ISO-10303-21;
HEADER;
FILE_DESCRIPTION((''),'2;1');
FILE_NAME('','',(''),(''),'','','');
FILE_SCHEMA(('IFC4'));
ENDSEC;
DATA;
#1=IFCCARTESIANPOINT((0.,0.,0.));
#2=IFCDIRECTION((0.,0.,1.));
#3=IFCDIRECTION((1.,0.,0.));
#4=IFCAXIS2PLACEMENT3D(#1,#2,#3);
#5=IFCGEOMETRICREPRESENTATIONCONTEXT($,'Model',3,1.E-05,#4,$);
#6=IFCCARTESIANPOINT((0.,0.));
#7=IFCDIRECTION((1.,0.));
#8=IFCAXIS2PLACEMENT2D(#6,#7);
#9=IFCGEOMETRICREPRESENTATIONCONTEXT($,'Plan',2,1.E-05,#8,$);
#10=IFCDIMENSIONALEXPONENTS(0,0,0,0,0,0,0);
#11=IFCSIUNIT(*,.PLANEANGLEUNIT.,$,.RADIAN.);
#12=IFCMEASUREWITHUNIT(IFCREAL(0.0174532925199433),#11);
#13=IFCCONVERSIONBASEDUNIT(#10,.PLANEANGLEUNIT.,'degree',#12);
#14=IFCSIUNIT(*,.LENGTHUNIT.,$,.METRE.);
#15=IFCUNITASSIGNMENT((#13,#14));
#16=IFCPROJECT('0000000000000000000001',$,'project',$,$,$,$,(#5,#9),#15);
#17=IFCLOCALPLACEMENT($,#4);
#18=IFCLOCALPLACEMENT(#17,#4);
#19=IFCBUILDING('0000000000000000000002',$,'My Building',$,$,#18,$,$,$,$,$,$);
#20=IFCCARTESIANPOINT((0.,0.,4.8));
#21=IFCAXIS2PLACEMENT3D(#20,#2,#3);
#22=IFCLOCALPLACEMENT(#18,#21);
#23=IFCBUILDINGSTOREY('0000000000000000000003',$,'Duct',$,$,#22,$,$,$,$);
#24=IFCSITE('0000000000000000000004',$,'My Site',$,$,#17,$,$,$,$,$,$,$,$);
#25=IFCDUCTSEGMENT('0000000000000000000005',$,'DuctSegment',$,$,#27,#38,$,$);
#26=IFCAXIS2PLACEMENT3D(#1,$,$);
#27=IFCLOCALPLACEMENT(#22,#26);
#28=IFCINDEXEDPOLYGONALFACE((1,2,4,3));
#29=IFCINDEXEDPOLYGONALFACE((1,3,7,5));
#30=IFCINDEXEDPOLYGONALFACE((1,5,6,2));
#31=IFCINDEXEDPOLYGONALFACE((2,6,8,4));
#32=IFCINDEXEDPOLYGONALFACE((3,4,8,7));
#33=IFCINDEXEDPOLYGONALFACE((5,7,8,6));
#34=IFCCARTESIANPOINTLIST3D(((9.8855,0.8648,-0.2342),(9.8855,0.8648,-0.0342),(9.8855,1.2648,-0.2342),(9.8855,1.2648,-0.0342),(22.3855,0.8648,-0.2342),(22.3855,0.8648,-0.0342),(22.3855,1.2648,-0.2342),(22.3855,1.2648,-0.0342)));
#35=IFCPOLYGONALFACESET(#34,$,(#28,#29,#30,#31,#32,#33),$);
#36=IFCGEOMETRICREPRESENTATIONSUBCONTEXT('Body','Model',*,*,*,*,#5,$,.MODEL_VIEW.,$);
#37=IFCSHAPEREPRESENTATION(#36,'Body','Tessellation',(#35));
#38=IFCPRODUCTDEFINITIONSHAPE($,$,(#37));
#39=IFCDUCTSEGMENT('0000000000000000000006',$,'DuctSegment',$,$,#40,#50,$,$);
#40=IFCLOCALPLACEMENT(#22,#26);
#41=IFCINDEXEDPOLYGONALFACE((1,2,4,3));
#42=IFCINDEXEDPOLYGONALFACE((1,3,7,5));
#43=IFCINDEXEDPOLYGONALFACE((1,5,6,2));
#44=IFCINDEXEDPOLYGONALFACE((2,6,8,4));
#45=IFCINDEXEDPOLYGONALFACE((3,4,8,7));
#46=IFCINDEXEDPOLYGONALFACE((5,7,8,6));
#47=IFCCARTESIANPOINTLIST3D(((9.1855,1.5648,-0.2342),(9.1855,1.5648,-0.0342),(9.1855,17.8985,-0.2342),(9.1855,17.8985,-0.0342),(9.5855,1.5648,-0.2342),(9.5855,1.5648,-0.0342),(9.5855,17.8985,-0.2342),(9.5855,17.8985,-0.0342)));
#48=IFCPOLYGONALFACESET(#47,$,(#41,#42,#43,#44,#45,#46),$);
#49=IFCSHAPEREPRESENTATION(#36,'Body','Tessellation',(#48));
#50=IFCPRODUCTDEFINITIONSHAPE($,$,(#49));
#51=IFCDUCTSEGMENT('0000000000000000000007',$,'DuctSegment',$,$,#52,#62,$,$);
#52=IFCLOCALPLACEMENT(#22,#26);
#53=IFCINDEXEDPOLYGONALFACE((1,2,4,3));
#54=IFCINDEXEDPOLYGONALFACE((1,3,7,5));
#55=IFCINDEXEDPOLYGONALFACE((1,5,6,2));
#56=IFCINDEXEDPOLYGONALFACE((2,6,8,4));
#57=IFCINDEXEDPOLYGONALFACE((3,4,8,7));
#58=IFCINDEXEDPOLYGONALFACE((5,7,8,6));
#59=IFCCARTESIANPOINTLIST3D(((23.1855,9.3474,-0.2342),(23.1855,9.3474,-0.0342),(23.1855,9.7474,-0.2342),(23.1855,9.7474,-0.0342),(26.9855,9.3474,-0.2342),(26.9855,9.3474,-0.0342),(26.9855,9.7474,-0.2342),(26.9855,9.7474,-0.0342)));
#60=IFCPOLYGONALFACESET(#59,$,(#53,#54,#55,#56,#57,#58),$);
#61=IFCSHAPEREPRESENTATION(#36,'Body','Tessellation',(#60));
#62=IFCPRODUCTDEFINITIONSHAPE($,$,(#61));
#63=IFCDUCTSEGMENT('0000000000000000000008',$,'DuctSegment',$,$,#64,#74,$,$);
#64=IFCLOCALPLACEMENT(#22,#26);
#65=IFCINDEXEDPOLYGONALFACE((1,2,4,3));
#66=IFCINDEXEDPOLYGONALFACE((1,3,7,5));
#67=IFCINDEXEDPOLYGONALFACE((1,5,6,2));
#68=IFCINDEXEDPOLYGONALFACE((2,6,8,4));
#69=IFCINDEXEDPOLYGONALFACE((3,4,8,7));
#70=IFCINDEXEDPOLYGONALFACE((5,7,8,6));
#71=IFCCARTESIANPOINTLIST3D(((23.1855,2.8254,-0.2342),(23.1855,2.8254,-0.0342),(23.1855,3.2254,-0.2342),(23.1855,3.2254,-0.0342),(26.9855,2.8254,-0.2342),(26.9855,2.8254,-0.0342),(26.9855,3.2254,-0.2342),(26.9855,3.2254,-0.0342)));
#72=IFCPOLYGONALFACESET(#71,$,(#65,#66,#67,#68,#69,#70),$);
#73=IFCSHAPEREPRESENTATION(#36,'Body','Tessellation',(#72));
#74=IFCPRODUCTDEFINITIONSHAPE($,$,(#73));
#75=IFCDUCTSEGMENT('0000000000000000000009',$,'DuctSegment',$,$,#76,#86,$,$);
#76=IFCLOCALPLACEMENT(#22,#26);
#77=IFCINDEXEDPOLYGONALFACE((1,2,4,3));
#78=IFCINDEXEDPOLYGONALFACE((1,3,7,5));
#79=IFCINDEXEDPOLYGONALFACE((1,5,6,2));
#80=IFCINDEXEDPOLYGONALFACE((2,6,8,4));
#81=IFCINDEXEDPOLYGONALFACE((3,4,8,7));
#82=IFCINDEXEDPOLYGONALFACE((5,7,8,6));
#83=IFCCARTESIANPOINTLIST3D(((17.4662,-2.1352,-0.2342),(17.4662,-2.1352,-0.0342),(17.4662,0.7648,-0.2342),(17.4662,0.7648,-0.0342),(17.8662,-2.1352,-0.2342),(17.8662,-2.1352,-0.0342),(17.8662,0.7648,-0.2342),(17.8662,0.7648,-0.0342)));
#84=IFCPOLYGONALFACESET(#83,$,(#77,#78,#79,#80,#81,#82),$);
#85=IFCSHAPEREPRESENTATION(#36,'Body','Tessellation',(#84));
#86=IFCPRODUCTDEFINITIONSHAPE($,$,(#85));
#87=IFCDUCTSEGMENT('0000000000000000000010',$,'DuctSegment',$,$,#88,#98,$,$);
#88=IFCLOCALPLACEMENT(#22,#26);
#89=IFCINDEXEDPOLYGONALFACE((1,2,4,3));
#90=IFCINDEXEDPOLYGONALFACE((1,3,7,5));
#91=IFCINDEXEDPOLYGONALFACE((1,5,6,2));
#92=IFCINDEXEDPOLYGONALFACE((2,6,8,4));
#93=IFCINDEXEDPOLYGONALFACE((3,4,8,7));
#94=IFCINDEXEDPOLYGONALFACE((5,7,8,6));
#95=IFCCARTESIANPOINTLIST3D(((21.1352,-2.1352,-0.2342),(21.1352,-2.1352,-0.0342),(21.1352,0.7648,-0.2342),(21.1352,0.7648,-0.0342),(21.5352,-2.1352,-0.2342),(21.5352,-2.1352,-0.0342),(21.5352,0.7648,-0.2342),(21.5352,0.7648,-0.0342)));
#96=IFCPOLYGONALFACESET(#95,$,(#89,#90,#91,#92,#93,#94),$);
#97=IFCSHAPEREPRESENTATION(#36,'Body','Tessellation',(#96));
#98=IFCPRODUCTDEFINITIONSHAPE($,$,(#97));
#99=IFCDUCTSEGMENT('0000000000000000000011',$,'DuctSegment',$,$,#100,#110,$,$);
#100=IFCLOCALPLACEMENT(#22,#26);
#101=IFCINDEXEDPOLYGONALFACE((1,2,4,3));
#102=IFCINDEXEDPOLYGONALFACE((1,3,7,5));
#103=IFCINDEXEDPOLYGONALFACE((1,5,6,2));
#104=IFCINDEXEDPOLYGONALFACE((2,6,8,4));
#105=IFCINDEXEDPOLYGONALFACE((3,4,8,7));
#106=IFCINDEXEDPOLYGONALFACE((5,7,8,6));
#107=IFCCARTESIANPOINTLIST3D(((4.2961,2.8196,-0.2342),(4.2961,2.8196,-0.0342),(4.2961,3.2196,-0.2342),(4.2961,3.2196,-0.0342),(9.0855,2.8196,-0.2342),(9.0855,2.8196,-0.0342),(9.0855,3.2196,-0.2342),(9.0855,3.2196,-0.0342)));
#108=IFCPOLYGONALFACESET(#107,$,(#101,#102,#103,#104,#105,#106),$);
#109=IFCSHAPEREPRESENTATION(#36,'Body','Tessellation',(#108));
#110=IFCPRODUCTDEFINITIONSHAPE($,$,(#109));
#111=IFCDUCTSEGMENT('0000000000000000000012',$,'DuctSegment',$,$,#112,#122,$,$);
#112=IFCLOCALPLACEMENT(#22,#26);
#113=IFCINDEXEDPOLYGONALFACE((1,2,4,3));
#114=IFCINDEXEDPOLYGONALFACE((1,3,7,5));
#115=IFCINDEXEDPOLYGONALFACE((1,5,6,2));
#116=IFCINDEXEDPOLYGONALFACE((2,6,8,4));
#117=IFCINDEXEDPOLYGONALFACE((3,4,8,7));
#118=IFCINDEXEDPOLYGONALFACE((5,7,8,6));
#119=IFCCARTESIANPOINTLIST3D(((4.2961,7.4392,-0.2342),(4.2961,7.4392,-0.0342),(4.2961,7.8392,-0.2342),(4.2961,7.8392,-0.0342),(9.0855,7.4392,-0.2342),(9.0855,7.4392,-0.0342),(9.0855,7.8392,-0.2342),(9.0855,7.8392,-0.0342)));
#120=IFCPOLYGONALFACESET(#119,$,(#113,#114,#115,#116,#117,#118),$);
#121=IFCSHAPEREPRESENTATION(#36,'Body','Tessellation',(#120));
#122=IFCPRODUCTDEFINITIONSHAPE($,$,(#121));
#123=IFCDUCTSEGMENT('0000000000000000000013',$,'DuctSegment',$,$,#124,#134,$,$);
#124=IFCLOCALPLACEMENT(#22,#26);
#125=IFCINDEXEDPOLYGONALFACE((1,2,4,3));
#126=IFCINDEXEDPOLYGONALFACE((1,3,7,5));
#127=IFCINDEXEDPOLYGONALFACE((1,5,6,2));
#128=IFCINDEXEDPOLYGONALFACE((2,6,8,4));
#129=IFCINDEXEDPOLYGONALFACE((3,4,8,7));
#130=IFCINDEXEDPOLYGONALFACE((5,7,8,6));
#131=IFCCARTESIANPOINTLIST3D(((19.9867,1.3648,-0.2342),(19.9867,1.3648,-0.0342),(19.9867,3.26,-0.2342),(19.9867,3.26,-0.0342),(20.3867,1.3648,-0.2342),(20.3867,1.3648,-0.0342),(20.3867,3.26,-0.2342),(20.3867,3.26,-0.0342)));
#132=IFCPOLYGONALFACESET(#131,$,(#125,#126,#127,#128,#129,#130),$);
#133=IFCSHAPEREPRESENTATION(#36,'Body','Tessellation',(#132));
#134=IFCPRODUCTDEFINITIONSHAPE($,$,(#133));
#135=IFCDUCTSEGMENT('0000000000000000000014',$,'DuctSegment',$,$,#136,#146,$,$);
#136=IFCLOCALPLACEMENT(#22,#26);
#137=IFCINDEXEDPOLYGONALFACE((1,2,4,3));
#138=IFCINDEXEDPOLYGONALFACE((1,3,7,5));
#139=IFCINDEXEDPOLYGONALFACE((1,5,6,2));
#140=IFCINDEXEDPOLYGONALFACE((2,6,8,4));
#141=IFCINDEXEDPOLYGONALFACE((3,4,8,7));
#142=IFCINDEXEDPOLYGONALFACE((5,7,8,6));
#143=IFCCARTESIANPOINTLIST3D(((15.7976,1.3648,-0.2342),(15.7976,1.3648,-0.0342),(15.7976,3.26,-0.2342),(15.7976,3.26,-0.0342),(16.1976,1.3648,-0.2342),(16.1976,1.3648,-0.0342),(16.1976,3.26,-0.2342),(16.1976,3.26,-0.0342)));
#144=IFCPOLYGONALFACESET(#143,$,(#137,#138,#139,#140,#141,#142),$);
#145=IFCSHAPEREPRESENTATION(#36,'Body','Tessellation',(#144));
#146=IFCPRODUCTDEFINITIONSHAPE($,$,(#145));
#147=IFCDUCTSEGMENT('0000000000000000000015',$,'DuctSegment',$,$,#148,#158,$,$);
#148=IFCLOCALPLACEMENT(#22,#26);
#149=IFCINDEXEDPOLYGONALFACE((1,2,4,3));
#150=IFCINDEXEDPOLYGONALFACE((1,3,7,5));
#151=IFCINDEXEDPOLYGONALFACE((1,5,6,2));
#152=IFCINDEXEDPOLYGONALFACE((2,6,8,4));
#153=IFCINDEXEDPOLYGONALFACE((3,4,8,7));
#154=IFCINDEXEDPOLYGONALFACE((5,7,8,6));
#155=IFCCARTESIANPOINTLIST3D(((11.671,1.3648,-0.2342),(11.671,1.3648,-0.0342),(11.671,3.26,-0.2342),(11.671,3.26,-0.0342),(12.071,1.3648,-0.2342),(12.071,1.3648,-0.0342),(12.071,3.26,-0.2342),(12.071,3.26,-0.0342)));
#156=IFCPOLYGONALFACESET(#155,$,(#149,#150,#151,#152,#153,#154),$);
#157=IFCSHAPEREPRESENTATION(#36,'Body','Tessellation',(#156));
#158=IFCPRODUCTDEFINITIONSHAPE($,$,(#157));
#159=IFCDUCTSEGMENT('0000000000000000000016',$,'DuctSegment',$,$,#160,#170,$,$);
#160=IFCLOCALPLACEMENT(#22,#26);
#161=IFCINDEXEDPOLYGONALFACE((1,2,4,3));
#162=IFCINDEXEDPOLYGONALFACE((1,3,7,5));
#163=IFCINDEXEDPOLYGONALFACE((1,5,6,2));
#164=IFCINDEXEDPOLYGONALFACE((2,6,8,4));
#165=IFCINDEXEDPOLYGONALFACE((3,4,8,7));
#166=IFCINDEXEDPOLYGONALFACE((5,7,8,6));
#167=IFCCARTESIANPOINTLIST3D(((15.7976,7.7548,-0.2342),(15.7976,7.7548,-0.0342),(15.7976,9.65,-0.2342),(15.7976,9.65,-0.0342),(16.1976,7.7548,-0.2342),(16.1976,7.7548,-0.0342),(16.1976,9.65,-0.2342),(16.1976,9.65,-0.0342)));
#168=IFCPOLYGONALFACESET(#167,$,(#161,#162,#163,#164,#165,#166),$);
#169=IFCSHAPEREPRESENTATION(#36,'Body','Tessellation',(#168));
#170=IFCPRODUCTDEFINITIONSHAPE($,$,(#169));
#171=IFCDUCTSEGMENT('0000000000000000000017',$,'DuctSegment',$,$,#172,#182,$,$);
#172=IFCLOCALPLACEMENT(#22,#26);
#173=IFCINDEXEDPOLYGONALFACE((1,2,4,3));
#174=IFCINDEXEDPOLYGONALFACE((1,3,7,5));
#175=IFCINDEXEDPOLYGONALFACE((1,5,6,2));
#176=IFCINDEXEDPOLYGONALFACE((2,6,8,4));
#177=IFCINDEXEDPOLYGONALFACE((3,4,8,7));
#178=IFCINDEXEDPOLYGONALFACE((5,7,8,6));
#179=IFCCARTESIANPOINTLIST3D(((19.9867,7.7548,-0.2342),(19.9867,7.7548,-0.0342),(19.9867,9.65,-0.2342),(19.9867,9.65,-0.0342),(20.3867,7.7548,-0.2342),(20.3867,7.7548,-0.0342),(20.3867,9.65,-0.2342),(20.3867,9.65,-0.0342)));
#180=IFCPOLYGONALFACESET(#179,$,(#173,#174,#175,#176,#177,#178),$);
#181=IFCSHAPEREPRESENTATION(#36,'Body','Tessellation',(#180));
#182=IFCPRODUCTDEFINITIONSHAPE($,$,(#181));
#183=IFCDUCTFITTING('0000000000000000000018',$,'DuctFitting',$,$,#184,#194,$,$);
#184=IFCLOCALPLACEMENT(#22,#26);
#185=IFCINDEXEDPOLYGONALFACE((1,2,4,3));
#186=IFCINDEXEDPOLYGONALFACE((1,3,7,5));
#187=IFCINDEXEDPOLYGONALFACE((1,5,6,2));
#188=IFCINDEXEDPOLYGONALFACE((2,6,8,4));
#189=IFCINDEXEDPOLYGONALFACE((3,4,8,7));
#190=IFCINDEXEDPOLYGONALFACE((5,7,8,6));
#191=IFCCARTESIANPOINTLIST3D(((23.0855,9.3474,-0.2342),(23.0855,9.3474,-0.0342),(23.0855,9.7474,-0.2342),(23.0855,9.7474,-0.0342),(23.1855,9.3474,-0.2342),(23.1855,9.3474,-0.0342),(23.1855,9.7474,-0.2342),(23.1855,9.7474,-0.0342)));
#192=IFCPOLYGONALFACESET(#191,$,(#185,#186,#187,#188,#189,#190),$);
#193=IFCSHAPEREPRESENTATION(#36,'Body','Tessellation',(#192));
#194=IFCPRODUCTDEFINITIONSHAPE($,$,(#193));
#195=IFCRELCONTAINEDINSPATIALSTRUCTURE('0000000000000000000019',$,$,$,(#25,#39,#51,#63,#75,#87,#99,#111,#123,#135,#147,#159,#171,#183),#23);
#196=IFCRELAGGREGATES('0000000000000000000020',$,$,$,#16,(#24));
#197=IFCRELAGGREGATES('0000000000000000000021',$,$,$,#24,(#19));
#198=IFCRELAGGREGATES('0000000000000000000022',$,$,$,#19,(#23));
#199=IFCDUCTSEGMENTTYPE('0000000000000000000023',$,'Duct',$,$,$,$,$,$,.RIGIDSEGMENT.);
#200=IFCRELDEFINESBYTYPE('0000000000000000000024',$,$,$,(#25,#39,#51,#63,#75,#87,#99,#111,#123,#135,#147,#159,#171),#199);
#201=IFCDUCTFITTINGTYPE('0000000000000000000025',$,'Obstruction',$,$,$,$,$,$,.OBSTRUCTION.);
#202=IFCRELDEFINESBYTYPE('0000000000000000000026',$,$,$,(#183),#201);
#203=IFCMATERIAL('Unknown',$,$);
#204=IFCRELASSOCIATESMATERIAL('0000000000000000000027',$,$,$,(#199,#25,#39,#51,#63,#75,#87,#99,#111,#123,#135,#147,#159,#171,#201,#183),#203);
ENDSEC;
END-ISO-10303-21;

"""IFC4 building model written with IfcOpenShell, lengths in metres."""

from ifc_helpers import new_model, entity, si_unit, converted_unit, frame, origin_with_axes, origin_2d_with_axis, place, context, subcontext, project, spatial, rectangle, extrude, material, material_profile, profile_set, profile_usage, type_object, element, save


model = new_model("IFC4")

# Units and contexts
model_context = context("Model", 3, precision=1e-05, world=origin_with_axes())
plan_context = context("Plan", 2, precision=1e-05, world=origin_2d_with_axis())
body_context = subcontext(model_context, "Body", "Model", "MODEL_VIEW")
ifc_project = project(units=[converted_unit("PLANEANGLEUNIT", "degree", entity("IfcReal", 0.0174532925199433), si_unit("PLANEANGLEUNIT", "RADIAN"), dimensions=[0, 0, 0, 0, 0, 0, 0]), si_unit("LENGTHUNIT", "METRE")], contexts=[model_context, plan_context])

# Site, building, storey
site_placement = place(None, origin_with_axes())
site = spatial("IfcSite", under=ifc_project, at=site_placement, Name="My Site")
building_placement = place(site_placement, origin_with_axes())
building = spatial("IfcBuilding", under=site, at=building_placement, Name="My Building")
storey_placement = place(building_placement, frame((0.0, 0.0, 4.8), z_axis=(0.0, 0.0, 1.0), x_axis=(1.0, 0.0, 0.0)))
storey = spatial("IfcBuildingStorey", under=building, at=storey_placement, Name="Duct")

# Duct segments
ifc_material = material(Name="Unknown")
ifc_material_profile_1 = material_profile(ifc_material, rectangle(XDim=0.4, YDim=0.2))
ifc_profile_set_1 = profile_set([ifc_material_profile_1])
ifc_profile_usage_1 = profile_usage(ifc_profile_set_1, cardinal=5)
duct_segment_type = type_object("IfcDuctSegmentType", Name="Duct", PredefinedType="RIGIDSEGMENT", material=ifc_profile_set_1)
duct_segment_1_placement = place(storey_placement, frame((22.3855, 1.0648, -0.1342), z_axis=(-1.0, 0.0, 0.0), x_axis=(0.0, -1.0, 0.0)))
element("IfcDuctSegment", 1, at=duct_segment_1_placement, inside=storey, type_object=duct_segment_type, material=ifc_profile_usage_1, Name="DuctSegment", context=body_context, shape_type="SweptSolid", body=[
    extrude(rectangle(XDim=0.4, YDim=0.2), origin_with_axes(), (0.0, 0.0, 1.0), 12.5),
])
ifc_profile_usage_2 = profile_usage(ifc_profile_set_1, cardinal=5)
duct_segment_2_placement = place(storey_placement, frame((9.3855, 1.5648, -0.1342), z_axis=(0.0, 1.0, 0.0), x_axis=(-1.0, 0.0, 0.0)))
element("IfcDuctSegment", 2, at=duct_segment_2_placement, inside=storey, type_object=duct_segment_type, material=ifc_profile_usage_2, Name="DuctSegment", context=body_context, shape_type="SweptSolid", body=[
    extrude(rectangle(XDim=0.4, YDim=0.2), origin_with_axes(), (0.0, 0.0, 1.0), 16.3337),
])
ifc_profile_usage_3 = profile_usage(ifc_profile_set_1, cardinal=5)
duct_segment_3_placement = place(storey_placement, frame((23.1855, 9.5474, -0.1342), z_axis=(1.0, -0.000001, 0.000001), x_axis=(0.000001, 1.0, 0.0)))
element("IfcDuctSegment", 3, at=duct_segment_3_placement, inside=storey, type_object=duct_segment_type, material=ifc_profile_usage_3, Name="DuctSegment", context=body_context, shape_type="SweptSolid", body=[
    extrude(rectangle(XDim=0.4, YDim=0.2), origin_with_axes(), (0.0, 0.0, 1.0), 3.8),
])
ifc_profile_usage_4 = profile_usage(ifc_profile_set_1, cardinal=5)
duct_segment_4_placement = place(storey_placement, frame((23.1855, 3.0254, -0.1342), z_axis=(1.0, -0.000001, 0.000001), x_axis=(0.000001, 1.0, 0.0)))
element("IfcDuctSegment", 4, at=duct_segment_4_placement, inside=storey, type_object=duct_segment_type, material=ifc_profile_usage_4, Name="DuctSegment", context=body_context, shape_type="SweptSolid", body=[
    extrude(rectangle(XDim=0.4, YDim=0.2), origin_with_axes(), (0.0, 0.0, 1.0), 3.8),
])
ifc_profile_usage_5 = profile_usage(ifc_profile_set_1, cardinal=5)
duct_segment_5_placement = place(storey_placement, frame((17.6662, 0.7648, -0.1342), z_axis=(0.0, -1.0, -0.000001), x_axis=(1.0, 0.0, 0.0)))
element("IfcDuctSegment", 5, at=duct_segment_5_placement, inside=storey, type_object=duct_segment_type, material=ifc_profile_usage_5, Name="DuctSegment", context=body_context, shape_type="SweptSolid", body=[
    extrude(rectangle(XDim=0.4, YDim=0.2), origin_with_axes(), (0.0, 0.0, 1.0), 2.9),
])
ifc_profile_usage_6 = profile_usage(ifc_profile_set_1, cardinal=5)
duct_segment_6_placement = place(storey_placement, frame((21.3352, 0.7648, -0.1342), z_axis=(0.0, -1.0, -0.000001), x_axis=(1.0, 0.0, 0.0)))
element("IfcDuctSegment", 6, at=duct_segment_6_placement, inside=storey, type_object=duct_segment_type, material=ifc_profile_usage_6, Name="DuctSegment", context=body_context, shape_type="SweptSolid", body=[
    extrude(rectangle(XDim=0.4, YDim=0.2), origin_with_axes(), (0.0, 0.0, 1.0), 2.9),
])
ifc_profile_usage_7 = profile_usage(ifc_profile_set_1, cardinal=5)
duct_segment_7_placement = place(storey_placement, frame((9.0855, 3.0196, -0.1342), z_axis=(-1.0, 0.0, 0.0), x_axis=(0.0, -1.0, 0.0)))
element("IfcDuctSegment", 7, at=duct_segment_7_placement, inside=storey, type_object=duct_segment_type, material=ifc_profile_usage_7, Name="DuctSegment", context=body_context, shape_type="SweptSolid", body=[
    extrude(rectangle(XDim=0.4, YDim=0.2), origin_with_axes(), (0.0, 0.0, 1.0), 4.7893),
])
ifc_profile_usage_8 = profile_usage(ifc_profile_set_1, cardinal=5)
duct_segment_8_placement = place(storey_placement, frame((9.0855, 7.6392, -0.1342), z_axis=(-1.0, 0.0, 0.0), x_axis=(0.0, -1.0, 0.0)))
element("IfcDuctSegment", 8, at=duct_segment_8_placement, inside=storey, type_object=duct_segment_type, material=ifc_profile_usage_8, Name="DuctSegment", context=body_context, shape_type="SweptSolid", body=[
    extrude(rectangle(XDim=0.4, YDim=0.2), origin_with_axes(), (0.0, 0.0, 1.0), 4.7893),
])
ifc_profile_usage_9 = profile_usage(ifc_profile_set_1, cardinal=5)
duct_segment_9_placement = place(storey_placement, frame((20.1867, 3.26, -0.1342), z_axis=(0.000001, -1.0, 0.0), x_axis=(1.0, 0.000001, 0.0)))
element("IfcDuctSegment", 9, at=duct_segment_9_placement, inside=storey, type_object=duct_segment_type, material=ifc_profile_usage_9, Name="DuctSegment", context=body_context, shape_type="SweptSolid", body=[
    extrude(rectangle(XDim=0.4, YDim=0.2), origin_with_axes(), (0.0, 0.0, 1.0), 1.8952),
])
ifc_profile_usage_10 = profile_usage(ifc_profile_set_1, cardinal=5)
duct_segment_10_placement = place(storey_placement, frame((15.9976, 3.26, -0.1342), z_axis=(0.000001, -1.0, 0.0), x_axis=(1.0, 0.000001, 0.0)))
element("IfcDuctSegment", 10, at=duct_segment_10_placement, inside=storey, type_object=duct_segment_type, material=ifc_profile_usage_10, Name="DuctSegment", context=body_context, shape_type="SweptSolid", body=[
    extrude(rectangle(XDim=0.4, YDim=0.2), origin_with_axes(), (0.0, 0.0, 1.0), 1.8952),
])
ifc_profile_usage_11 = profile_usage(ifc_profile_set_1, cardinal=5)
duct_segment_11_placement = place(storey_placement, frame((11.871, 3.26, -0.1342), z_axis=(0.000001, -1.0, 0.0), x_axis=(1.0, 0.000001, 0.0)))
element("IfcDuctSegment", 11, at=duct_segment_11_placement, inside=storey, type_object=duct_segment_type, material=ifc_profile_usage_11, Name="DuctSegment", context=body_context, shape_type="SweptSolid", body=[
    extrude(rectangle(XDim=0.4, YDim=0.2), origin_with_axes(), (0.0, 0.0, 1.0), 1.8952),
])
ifc_profile_usage_12 = profile_usage(ifc_profile_set_1, cardinal=5)
duct_segment_12_placement = place(storey_placement, frame((15.9976, 7.7548, -0.1342), z_axis=(0.0, 1.0, 0.0), x_axis=(-1.0, 0.0, 0.0)))
element("IfcDuctSegment", 12, at=duct_segment_12_placement, inside=storey, type_object=duct_segment_type, material=ifc_profile_usage_12, Name="DuctSegment", context=body_context, shape_type="SweptSolid", body=[
    extrude(rectangle(XDim=0.4, YDim=0.2), origin_with_axes(), (0.0, 0.0, 1.0), 1.8952),
])
ifc_profile_usage_13 = profile_usage(ifc_profile_set_1, cardinal=5)
duct_segment_13_placement = place(storey_placement, frame((20.1867, 7.7548, -0.1342), z_axis=(0.0, 1.0, 0.0), x_axis=(-1.0, 0.0, 0.0)))
element("IfcDuctSegment", 13, at=duct_segment_13_placement, inside=storey, type_object=duct_segment_type, material=ifc_profile_usage_13, Name="DuctSegment", context=body_context, shape_type="SweptSolid", body=[
    extrude(rectangle(XDim=0.4, YDim=0.2), origin_with_axes(), (0.0, 0.0, 1.0), 1.8952),
])

# Duct fitting
ifc_material_profile_2 = material_profile(ifc_material, rectangle(XDim=0.4, YDim=0.2))
ifc_profile_set_2 = profile_set([ifc_material_profile_2])
ifc_profile_usage_14 = profile_usage(ifc_profile_set_2, cardinal=5)
duct_fitting_type_1 = type_object("IfcDuctFittingType", Name="Obstruction", PredefinedType="OBSTRUCTION", material=ifc_profile_set_2)
duct_fitting_1_placement = place(storey_placement, frame((23.0855, 9.5474, -0.1342), z_axis=(1.0, -0.000001, 0.000001), x_axis=(0.000001, 1.0, 0.0)))
element("IfcDuctFitting", 14, at=duct_fitting_1_placement, inside=storey, type_object=duct_fitting_type_1, material=ifc_profile_usage_14, Name="DuctFitting", context=body_context, shape_type="SweptSolid", body=[
    extrude(rectangle(XDim=0.4, YDim=0.2), origin_with_axes(), (0.0, 0.0, 1.0), 0.1),
])

save(model, "model.ifc")
